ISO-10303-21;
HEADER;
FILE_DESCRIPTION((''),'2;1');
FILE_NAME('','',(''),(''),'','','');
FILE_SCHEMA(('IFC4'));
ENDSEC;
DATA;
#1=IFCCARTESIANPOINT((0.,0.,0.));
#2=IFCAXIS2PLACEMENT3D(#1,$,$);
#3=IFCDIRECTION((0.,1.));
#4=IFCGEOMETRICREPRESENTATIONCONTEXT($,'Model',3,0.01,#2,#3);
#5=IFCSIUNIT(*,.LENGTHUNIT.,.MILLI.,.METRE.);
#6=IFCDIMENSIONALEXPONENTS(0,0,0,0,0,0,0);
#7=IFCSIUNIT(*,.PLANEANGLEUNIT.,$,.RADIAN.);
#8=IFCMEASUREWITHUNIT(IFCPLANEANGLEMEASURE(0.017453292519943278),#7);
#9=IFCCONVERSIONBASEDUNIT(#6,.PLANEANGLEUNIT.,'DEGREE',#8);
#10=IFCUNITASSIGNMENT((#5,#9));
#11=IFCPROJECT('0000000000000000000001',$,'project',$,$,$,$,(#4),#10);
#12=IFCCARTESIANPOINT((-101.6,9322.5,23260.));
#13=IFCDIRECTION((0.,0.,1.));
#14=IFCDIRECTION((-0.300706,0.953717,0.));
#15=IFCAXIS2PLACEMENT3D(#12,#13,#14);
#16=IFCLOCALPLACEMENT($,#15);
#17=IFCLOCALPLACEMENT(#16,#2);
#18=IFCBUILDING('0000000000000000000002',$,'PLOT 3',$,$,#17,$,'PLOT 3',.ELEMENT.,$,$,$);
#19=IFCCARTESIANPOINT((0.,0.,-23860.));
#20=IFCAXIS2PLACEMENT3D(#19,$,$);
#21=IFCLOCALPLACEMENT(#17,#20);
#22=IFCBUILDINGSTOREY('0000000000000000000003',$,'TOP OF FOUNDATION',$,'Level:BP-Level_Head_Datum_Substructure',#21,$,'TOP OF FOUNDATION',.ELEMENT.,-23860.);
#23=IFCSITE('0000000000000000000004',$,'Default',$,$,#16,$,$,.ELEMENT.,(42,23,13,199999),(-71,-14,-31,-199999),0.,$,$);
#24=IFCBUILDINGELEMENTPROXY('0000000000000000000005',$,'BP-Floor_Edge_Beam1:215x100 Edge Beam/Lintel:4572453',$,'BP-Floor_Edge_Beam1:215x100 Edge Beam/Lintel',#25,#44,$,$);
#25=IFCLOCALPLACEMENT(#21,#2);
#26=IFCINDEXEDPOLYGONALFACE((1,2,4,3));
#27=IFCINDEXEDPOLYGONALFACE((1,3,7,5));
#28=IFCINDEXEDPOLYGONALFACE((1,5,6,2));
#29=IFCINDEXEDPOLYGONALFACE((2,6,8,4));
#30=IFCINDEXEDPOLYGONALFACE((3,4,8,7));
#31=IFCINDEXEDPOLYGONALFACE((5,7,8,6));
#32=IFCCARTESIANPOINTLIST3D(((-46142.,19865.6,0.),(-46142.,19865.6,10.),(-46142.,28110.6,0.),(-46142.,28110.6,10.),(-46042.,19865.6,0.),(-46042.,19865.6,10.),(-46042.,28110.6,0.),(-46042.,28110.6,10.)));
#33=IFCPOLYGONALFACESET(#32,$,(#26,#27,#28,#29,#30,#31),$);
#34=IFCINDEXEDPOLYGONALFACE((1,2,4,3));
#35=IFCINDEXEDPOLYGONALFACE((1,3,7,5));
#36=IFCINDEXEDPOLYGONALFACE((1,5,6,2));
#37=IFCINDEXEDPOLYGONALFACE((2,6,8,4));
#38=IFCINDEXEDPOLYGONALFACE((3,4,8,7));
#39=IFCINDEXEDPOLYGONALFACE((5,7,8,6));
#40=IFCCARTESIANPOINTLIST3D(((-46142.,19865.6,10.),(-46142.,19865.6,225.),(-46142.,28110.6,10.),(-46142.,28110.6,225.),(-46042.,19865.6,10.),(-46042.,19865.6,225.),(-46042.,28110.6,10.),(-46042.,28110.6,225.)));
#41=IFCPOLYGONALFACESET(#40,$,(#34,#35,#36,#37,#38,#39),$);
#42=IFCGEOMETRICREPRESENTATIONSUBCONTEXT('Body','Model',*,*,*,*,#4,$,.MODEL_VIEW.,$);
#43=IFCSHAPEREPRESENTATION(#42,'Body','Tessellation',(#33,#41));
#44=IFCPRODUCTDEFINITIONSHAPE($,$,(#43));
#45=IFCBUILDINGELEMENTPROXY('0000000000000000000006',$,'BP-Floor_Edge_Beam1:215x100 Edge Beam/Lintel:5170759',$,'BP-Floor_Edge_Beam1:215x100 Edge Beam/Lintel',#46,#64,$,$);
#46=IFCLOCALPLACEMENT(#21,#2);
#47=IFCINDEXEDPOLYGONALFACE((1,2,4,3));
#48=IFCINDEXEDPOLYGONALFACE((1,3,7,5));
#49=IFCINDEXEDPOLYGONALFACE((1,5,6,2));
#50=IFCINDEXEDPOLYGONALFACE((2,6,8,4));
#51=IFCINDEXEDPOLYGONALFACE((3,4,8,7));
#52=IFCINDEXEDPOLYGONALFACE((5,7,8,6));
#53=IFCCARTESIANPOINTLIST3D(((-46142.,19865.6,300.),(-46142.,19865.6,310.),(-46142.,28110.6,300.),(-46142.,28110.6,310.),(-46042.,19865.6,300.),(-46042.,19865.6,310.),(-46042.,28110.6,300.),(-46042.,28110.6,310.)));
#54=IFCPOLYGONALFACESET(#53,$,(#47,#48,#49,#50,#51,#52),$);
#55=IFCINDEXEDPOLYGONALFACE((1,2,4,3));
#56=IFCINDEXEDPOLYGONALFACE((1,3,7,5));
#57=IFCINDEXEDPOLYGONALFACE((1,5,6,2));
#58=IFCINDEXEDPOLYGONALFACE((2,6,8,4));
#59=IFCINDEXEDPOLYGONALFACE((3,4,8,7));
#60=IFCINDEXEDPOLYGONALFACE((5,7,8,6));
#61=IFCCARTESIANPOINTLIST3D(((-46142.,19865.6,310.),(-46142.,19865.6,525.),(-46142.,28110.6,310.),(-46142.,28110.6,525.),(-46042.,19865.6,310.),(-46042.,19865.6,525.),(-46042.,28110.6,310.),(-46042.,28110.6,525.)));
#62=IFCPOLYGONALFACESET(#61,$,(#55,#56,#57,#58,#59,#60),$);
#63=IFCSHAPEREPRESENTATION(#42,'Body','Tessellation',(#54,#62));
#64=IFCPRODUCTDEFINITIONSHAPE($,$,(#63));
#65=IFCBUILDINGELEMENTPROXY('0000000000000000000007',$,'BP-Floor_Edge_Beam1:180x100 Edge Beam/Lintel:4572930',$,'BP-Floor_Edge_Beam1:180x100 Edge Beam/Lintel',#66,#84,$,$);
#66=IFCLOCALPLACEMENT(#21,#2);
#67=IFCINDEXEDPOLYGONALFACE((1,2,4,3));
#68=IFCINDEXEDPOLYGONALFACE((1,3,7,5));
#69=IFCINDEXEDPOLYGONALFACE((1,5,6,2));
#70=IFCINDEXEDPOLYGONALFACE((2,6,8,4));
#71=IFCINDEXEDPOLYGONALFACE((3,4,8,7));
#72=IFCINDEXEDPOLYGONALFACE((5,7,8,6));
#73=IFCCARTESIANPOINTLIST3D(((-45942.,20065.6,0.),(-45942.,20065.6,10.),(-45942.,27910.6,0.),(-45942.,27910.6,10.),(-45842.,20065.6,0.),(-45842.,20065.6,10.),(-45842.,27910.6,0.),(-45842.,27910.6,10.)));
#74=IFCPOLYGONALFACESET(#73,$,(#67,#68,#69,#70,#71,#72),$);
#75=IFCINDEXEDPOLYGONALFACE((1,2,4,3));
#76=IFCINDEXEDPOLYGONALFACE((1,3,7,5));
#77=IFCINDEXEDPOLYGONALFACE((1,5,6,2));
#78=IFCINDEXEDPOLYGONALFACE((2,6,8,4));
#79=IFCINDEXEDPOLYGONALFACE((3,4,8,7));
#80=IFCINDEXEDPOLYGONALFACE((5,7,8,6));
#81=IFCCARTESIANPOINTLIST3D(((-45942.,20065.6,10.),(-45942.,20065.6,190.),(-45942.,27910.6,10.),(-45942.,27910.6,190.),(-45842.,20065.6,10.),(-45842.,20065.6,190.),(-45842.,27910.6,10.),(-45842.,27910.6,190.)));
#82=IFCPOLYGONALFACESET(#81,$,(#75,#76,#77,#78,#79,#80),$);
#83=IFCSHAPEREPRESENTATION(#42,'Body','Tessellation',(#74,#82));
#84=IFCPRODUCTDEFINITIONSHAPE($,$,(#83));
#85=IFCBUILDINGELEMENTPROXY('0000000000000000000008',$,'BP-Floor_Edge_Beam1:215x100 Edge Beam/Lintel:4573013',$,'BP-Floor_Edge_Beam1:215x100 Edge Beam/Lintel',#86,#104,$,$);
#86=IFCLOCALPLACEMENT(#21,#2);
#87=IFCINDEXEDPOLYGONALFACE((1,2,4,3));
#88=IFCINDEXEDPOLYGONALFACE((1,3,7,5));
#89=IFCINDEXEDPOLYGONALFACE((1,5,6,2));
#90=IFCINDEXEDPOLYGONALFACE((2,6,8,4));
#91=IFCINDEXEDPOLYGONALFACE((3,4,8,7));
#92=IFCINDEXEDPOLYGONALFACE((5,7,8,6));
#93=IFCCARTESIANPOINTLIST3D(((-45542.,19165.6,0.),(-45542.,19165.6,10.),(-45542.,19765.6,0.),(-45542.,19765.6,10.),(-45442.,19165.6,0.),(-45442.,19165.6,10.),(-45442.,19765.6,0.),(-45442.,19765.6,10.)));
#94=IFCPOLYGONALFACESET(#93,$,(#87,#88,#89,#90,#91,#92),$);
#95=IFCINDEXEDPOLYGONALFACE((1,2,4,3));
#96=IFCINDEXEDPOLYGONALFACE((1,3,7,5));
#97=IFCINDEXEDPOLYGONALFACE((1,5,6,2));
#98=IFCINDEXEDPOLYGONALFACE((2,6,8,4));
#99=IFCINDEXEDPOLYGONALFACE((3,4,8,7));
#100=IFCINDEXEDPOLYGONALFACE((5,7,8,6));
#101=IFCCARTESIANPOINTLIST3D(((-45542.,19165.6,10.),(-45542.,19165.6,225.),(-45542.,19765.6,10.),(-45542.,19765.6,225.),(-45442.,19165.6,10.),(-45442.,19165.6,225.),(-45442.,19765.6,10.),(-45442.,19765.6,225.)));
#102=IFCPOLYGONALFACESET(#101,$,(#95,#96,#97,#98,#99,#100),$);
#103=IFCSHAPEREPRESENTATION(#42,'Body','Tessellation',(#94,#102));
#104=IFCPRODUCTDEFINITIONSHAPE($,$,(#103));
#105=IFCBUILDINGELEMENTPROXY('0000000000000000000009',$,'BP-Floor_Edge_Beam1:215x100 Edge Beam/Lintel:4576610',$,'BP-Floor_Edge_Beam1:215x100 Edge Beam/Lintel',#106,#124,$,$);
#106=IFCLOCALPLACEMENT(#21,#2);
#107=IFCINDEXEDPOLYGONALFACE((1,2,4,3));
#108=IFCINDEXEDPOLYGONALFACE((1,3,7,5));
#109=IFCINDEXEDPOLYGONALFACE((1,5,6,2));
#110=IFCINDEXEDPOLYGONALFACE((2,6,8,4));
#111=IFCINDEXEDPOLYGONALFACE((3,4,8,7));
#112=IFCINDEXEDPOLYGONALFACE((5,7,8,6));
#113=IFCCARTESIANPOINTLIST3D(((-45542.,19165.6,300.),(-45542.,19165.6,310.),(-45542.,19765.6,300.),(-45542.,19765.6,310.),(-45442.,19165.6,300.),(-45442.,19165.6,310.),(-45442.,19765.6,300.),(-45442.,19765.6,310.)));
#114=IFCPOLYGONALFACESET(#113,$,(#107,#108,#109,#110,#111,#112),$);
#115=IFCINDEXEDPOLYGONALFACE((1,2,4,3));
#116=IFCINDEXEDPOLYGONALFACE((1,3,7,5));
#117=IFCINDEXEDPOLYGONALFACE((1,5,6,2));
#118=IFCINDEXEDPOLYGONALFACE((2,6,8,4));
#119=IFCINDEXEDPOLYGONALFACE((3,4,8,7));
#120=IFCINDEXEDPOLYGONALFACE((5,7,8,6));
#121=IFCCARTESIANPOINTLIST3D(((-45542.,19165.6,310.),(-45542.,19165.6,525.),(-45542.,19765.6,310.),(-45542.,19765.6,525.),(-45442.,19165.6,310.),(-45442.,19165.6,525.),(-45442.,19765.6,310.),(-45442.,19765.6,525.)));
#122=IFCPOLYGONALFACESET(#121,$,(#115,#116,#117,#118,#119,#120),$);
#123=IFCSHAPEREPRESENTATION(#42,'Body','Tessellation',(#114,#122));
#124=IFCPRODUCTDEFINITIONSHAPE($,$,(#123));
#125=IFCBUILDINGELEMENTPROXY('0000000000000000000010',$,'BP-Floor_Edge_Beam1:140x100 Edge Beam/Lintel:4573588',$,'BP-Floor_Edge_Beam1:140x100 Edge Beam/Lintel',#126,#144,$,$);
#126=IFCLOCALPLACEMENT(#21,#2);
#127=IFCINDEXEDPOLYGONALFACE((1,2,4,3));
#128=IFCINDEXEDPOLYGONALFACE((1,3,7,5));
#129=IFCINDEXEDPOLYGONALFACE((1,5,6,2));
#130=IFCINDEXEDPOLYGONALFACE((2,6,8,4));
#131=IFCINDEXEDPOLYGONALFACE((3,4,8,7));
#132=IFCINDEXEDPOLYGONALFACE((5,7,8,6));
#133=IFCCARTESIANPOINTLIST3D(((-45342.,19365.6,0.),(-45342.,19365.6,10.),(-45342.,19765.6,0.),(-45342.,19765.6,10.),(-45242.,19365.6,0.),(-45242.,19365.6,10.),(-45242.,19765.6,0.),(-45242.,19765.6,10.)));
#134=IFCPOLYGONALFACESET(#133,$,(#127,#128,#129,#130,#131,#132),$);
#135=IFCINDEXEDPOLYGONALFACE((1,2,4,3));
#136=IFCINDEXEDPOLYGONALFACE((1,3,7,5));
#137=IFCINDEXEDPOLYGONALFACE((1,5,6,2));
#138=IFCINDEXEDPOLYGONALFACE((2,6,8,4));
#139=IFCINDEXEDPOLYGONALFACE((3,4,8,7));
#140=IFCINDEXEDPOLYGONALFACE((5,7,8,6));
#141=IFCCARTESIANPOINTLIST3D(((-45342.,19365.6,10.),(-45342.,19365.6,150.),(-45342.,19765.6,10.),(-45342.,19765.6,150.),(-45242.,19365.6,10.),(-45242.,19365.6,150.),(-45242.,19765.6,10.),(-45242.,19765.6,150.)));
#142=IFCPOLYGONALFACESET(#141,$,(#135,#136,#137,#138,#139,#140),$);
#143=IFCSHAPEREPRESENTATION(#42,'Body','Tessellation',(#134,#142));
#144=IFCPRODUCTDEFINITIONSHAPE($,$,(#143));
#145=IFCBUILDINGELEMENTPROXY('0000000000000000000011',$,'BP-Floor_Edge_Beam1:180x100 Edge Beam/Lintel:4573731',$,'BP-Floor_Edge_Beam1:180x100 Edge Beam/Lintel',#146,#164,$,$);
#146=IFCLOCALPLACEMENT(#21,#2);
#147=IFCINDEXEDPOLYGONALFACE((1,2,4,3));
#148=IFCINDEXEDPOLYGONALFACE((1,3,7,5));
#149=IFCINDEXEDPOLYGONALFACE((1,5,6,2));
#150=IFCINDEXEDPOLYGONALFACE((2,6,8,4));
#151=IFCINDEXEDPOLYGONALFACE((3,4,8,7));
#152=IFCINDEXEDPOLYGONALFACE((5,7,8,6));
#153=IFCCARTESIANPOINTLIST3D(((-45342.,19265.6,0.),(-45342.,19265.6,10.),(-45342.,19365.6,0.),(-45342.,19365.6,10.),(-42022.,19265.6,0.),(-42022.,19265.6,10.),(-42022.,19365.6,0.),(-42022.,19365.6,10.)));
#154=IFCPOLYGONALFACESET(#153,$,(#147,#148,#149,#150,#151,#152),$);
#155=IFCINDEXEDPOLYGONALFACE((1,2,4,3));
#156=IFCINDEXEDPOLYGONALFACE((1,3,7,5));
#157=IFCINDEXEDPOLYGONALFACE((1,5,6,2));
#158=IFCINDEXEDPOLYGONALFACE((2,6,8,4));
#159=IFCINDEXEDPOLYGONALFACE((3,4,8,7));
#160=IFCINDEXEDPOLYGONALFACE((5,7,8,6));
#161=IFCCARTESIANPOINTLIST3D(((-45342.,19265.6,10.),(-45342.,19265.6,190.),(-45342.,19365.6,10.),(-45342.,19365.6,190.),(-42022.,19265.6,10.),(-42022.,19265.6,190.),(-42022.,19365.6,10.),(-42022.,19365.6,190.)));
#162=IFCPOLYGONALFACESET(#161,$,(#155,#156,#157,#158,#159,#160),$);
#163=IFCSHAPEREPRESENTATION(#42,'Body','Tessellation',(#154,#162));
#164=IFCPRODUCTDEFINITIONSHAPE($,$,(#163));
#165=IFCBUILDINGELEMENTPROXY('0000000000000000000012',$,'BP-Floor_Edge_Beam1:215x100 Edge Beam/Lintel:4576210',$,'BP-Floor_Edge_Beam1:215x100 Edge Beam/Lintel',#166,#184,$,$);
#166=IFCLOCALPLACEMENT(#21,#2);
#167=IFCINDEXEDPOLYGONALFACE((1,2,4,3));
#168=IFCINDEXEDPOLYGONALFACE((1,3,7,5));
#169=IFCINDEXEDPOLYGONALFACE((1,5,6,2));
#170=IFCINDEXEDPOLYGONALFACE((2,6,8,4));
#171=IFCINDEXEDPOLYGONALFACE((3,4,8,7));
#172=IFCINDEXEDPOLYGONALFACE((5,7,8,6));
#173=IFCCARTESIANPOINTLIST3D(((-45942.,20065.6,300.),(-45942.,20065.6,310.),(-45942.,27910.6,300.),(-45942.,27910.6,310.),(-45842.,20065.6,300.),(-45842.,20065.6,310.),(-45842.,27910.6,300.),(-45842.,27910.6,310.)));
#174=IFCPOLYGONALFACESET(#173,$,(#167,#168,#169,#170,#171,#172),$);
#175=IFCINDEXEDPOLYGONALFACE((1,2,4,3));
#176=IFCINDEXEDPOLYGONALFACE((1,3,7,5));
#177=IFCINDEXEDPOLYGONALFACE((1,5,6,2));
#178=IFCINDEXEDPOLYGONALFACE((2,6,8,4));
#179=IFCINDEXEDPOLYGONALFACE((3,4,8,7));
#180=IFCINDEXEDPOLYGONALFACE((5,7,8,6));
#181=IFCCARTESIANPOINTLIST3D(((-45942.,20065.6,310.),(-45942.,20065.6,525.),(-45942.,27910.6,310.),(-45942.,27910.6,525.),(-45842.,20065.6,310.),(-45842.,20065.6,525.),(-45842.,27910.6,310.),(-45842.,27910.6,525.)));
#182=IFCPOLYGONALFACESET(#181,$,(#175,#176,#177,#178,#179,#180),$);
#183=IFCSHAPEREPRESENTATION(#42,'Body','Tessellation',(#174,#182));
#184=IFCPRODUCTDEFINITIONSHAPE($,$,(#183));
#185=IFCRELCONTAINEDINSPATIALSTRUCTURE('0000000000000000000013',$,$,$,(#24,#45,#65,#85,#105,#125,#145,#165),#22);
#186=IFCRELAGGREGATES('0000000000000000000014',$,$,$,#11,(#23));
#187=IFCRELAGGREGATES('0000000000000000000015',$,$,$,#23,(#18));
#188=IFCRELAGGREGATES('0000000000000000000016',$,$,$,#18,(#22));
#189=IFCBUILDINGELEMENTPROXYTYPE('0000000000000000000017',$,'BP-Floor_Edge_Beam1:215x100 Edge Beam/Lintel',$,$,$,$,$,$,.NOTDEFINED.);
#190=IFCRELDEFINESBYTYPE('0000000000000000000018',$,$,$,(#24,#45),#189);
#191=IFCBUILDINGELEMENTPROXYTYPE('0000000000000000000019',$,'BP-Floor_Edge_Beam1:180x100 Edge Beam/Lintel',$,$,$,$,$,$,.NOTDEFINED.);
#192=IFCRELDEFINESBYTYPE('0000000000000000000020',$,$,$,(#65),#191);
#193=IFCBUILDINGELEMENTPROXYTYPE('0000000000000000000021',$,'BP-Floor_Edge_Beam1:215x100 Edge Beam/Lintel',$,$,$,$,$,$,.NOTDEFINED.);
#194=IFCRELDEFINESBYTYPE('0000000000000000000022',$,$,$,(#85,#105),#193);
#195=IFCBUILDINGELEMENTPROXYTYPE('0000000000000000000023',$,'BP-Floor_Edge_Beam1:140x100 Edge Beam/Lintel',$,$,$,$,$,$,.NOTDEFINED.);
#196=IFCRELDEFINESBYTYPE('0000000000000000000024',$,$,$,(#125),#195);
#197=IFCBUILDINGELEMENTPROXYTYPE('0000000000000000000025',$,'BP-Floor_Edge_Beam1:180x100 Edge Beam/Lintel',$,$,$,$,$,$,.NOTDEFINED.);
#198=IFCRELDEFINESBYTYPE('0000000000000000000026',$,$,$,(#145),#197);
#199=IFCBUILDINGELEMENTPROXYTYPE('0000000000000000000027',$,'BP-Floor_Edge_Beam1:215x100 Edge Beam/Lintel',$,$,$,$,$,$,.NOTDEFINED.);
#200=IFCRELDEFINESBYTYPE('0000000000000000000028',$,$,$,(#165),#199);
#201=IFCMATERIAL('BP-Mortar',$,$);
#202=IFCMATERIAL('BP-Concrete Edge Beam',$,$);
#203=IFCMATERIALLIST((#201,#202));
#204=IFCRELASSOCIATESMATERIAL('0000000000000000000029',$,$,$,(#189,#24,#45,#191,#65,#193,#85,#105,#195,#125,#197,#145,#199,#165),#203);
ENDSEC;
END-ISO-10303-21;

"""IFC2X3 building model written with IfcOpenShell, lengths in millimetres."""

from ifc_helpers import new_model, entity, si_unit, converted_unit, direction, frame, frame_2d, origin, origin_2d_with_axis, place, context, subcontext, project, spatial, rectangle, extrude, source, transform, mapped, material, material_list, type_object, type_shapes, element, save


model = new_model("IFC2X3")

# Units and contexts
model_context = context("Model", 3, precision=0.01, world=origin(), true_north=direction((0.0, 1.0)))
body_context = subcontext(model_context, "Body", "Model", "MODEL_VIEW")
ifc_project = project(units=[si_unit("LENGTHUNIT", "METRE", prefix="MILLI"), converted_unit("PLANEANGLEUNIT", "DEGREE", entity("IfcPlaneAngleMeasure", 0.017453292519943278), si_unit("PLANEANGLEUNIT", "RADIAN"), dimensions=[0, 0, 0, 0, 0, 0, 0])], contexts=[model_context])

# Site, building, storey
site_placement = place(None, frame((-101.6, 9322.5, 23260.0), z_axis=(0.0, 0.0, 1.0), x_axis=(-0.300706, 0.953717, 0.0)))
site = spatial("IfcSite", under=ifc_project, at=site_placement, Name="Default", CompositionType="ELEMENT", RefLatitude=(42, 23, 13, 199999), RefLongitude=(-71, -14, -31, -199999), RefElevation=0.0)
building_placement = place(site_placement, origin())
building = spatial("IfcBuilding", under=site, at=building_placement, Name="PLOT 3", LongName="PLOT 3", CompositionType="ELEMENT")
storey_placement = place(building_placement, frame((0.0, 0.0, -23860.0)))
storey = spatial("IfcBuildingStorey", under=building, at=storey_placement, Name="TOP OF FOUNDATION", ObjectType="Level:BP-Level_Head_Datum_Substructure", LongName="TOP OF FOUNDATION", CompositionType="ELEMENT", Elevation=-23860.0)

# Building element proxies
ifc_material_1 = material(Name="BP-Mortar")
ifc_material_2 = material(Name="BP-Concrete Edge Beam")
ifc_material_list = material_list([ifc_material_1, ifc_material_2])
building_element_proxy_type_1 = type_object("IfcBuildingElementProxyType", Name="BP-Floor_Edge_Beam1:215x100 Edge Beam/Lintel", PredefinedType="NOTDEFINED", material=ifc_material_list)
shared_shape_1 = source(origin(), body_context, "Body", "SweptSolid", [
    extrude(rectangle(XDim=100.0, YDim=8245.0, at=frame_2d((0.0, 0.0), x_axis=(1.0, 0.0))), frame((0.0, 0.0, 0.0), z_axis=(0.0, 0.0, 1.0), x_axis=(0.0, 1.0, 0.0)), (0.0, 0.0, 1.0), 10.0),
    extrude(rectangle(XDim=100.0, YDim=8245.0, at=origin_2d_with_axis()), frame((0.0, 0.0, 10.0), z_axis=(0.0, 0.0, 1.0), x_axis=(0.0, 1.0, 0.0)), (0.0, 0.0, 1.0), 215.0),
])
type_shapes(building_element_proxy_type_1, [shared_shape_1])
for number, where, z_axis, x_axis, name in (
    (1, (-46092.0, 23988.1, 0.0), (0.0, 0.0, 1.0), (0.0, 1.0, 0.0), "BP-Floor_Edge_Beam1:215x100 Edge Beam/Lintel:4572453"),
    (2, (-46092.0, 23988.1, 300.0), (0.0, 0.0, 1.0), (0.0, 1.0, 0.0), "BP-Floor_Edge_Beam1:215x100 Edge Beam/Lintel:5170759"),
):
    element("IfcBuildingElementProxy", number, at=place(storey_placement, frame(where, z_axis=z_axis, x_axis=x_axis)), inside=storey, type_object=building_element_proxy_type_1, material=ifc_material_list, Name=name, ObjectType="BP-Floor_Edge_Beam1:215x100 Edge Beam/Lintel", context=body_context, shape_type="MappedRepresentation", body=[
        mapped(shared_shape_1, transform((0.0, 0.0, 0.0), scale=1.0)),
    ])
building_element_proxy_type_2 = type_object("IfcBuildingElementProxyType", Name="BP-Floor_Edge_Beam1:180x100 Edge Beam/Lintel", PredefinedType="NOTDEFINED", material=ifc_material_list)
shared_shape_2 = source(origin(), body_context, "Body", "SweptSolid", [
    extrude(rectangle(XDim=100.0, YDim=7845.0, at=frame_2d((0.0, 0.0), x_axis=(1.0, 0.0))), frame((0.0, 0.0, 0.0), z_axis=(0.0, 0.0, 1.0), x_axis=(0.0, 1.0, 0.0)), (0.0, 0.0, 1.0), 10.0),
    extrude(rectangle(XDim=100.0, YDim=7845.0, at=origin_2d_with_axis()), frame((0.0, 0.0, 10.0), z_axis=(0.0, 0.0, 1.0), x_axis=(0.0, 1.0, 0.0)), (0.0, 0.0, 1.0), 180.0),
])
type_shapes(building_element_proxy_type_2, [shared_shape_2])
proxy_1_placement = place(storey_placement, frame((-45892.0, 23988.1, 0.0), z_axis=(0.0, 0.0, 1.0), x_axis=(0.0, 1.0, 0.0)))
element("IfcBuildingElementProxy", 3, at=proxy_1_placement, inside=storey, type_object=building_element_proxy_type_2, material=ifc_material_list, Name="BP-Floor_Edge_Beam1:180x100 Edge Beam/Lintel:4572930", ObjectType="BP-Floor_Edge_Beam1:180x100 Edge Beam/Lintel", context=body_context, shape_type="MappedRepresentation", body=[
    mapped(shared_shape_2, transform((0.0, 0.0, 0.0), scale=1.0)),
])
building_element_proxy_type_3 = type_object("IfcBuildingElementProxyType", Name="BP-Floor_Edge_Beam1:215x100 Edge Beam/Lintel", PredefinedType="NOTDEFINED", material=ifc_material_list)
shared_shape_3 = source(origin(), body_context, "Body", "SweptSolid", [
    extrude(rectangle(XDim=100.0, YDim=600.0, at=frame_2d((0.0, 0.0), x_axis=(1.0, 0.0))), frame((0.0, 0.0, 0.0), z_axis=(0.0, 0.0, 1.0), x_axis=(0.0, 1.0, 0.0)), (0.0, 0.0, 1.0), 10.0),
    extrude(rectangle(XDim=100.0, YDim=600.0, at=origin_2d_with_axis()), frame((0.0, 0.0, 10.0), z_axis=(0.0, 0.0, 1.0), x_axis=(0.0, 1.0, 0.0)), (0.0, 0.0, 1.0), 215.0),
])
type_shapes(building_element_proxy_type_3, [shared_shape_3])
for number, where, z_axis, x_axis, name in (
    (4, (-45492.0, 19465.6, 0.0), (0.0, 0.0, 1.0), (0.0, 1.0, 0.0), "BP-Floor_Edge_Beam1:215x100 Edge Beam/Lintel:4573013"),
    (5, (-45492.0, 19465.6, 300.0), (0.0, 0.0, 1.0), (0.0, 1.0, 0.0), "BP-Floor_Edge_Beam1:215x100 Edge Beam/Lintel:4576610"),
):
    element("IfcBuildingElementProxy", number, at=place(storey_placement, frame(where, z_axis=z_axis, x_axis=x_axis)), inside=storey, type_object=building_element_proxy_type_3, material=ifc_material_list, Name=name, ObjectType="BP-Floor_Edge_Beam1:215x100 Edge Beam/Lintel", context=body_context, shape_type="MappedRepresentation", body=[
        mapped(shared_shape_3, transform((0.0, 0.0, 0.0), scale=1.0)),
    ])
building_element_proxy_type_4 = type_object("IfcBuildingElementProxyType", Name="BP-Floor_Edge_Beam1:140x100 Edge Beam/Lintel", PredefinedType="NOTDEFINED", material=ifc_material_list)
shared_shape_4 = source(origin(), body_context, "Body", "SweptSolid", [
    extrude(rectangle(XDim=100.0, YDim=400.0, at=frame_2d((0.0, 0.0), x_axis=(1.0, 0.0))), frame((0.0, 0.0, 0.0), z_axis=(0.0, 0.0, 1.0), x_axis=(0.0, 1.0, 0.0)), (0.0, 0.0, 1.0), 10.0),
    extrude(rectangle(XDim=100.0, YDim=400.0, at=origin_2d_with_axis()), frame((0.0, 0.0, 10.0), z_axis=(0.0, 0.0, 1.0), x_axis=(0.0, 1.0, 0.0)), (0.0, 0.0, 1.0), 140.0),
])
type_shapes(building_element_proxy_type_4, [shared_shape_4])
proxy_2_placement = place(storey_placement, frame((-45292.0, 19565.6, 0.0), z_axis=(0.0, 0.0, 1.0), x_axis=(0.0, 1.0, 0.0)))
element("IfcBuildingElementProxy", 6, at=proxy_2_placement, inside=storey, type_object=building_element_proxy_type_4, material=ifc_material_list, Name="BP-Floor_Edge_Beam1:140x100 Edge Beam/Lintel:4573588", ObjectType="BP-Floor_Edge_Beam1:140x100 Edge Beam/Lintel", context=body_context, shape_type="MappedRepresentation", body=[
    mapped(shared_shape_4, transform((0.0, 0.0, 0.0), scale=1.0)),
])
building_element_proxy_type_5 = type_object("IfcBuildingElementProxyType", Name="BP-Floor_Edge_Beam1:180x100 Edge Beam/Lintel", PredefinedType="NOTDEFINED", material=ifc_material_list)
shared_shape_5 = source(origin(), body_context, "Body", "SweptSolid", [
    extrude(rectangle(XDim=100.0, YDim=3320.0, at=origin_2d_with_axis()), frame((0.0, 0.0, 0.0), z_axis=(0.0, 0.0, 1.0), x_axis=(0.0, 1.0, 0.0)), (0.0, 0.0, 1.0), 10.0),
    extrude(rectangle(XDim=100.0, YDim=3320.0, at=origin_2d_with_axis()), frame((0.0, 0.0, 10.0), z_axis=(0.0, 0.0, 1.0), x_axis=(0.0, 1.0, 0.0)), (0.0, 0.0, 1.0), 180.0),
])
type_shapes(building_element_proxy_type_5, [shared_shape_5])
proxy_3_placement = place(storey_placement, frame((-43682.0, 19315.6, 0.0), z_axis=(0.0, 0.0, 1.0), x_axis=(-1.0, 0.0, 0.0)))
element("IfcBuildingElementProxy", 7, at=proxy_3_placement, inside=storey, type_object=building_element_proxy_type_5, material=ifc_material_list, Name="BP-Floor_Edge_Beam1:180x100 Edge Beam/Lintel:4573731", ObjectType="BP-Floor_Edge_Beam1:180x100 Edge Beam/Lintel", context=body_context, shape_type="MappedRepresentation", body=[
    mapped(shared_shape_5, transform((0.0, 0.0, 0.0), scale=1.0)),
])
building_element_proxy_type_6 = type_object("IfcBuildingElementProxyType", Name="BP-Floor_Edge_Beam1:215x100 Edge Beam/Lintel", PredefinedType="NOTDEFINED", material=ifc_material_list)
shared_shape_6 = source(origin(), body_context, "Body", "SweptSolid", [
    extrude(rectangle(XDim=100.0, YDim=7845.0, at=frame_2d((0.0, 0.0), x_axis=(1.0, 0.0))), frame((0.0, 0.0, 0.0), z_axis=(0.0, 0.0, 1.0), x_axis=(0.0, 1.0, 0.0)), (0.0, 0.0, 1.0), 10.0),
    extrude(rectangle(XDim=100.0, YDim=7845.0, at=origin_2d_with_axis()), frame((0.0, 0.0, 10.0), z_axis=(0.0, 0.0, 1.0), x_axis=(0.0, 1.0, 0.0)), (0.0, 0.0, 1.0), 215.0),
])
type_shapes(building_element_proxy_type_6, [shared_shape_6])
proxy_4_placement = place(storey_placement, frame((-45892.0, 23988.1, 300.0), z_axis=(0.0, 0.0, 1.0), x_axis=(0.0, 1.0, 0.0)))
element("IfcBuildingElementProxy", 8, at=proxy_4_placement, inside=storey, type_object=building_element_proxy_type_6, material=ifc_material_list, Name="BP-Floor_Edge_Beam1:215x100 Edge Beam/Lintel:4576210", ObjectType="BP-Floor_Edge_Beam1:215x100 Edge Beam/Lintel", context=body_context, shape_type="MappedRepresentation", body=[
    mapped(shared_shape_6, transform((0.0, 0.0, 0.0), scale=1.0)),
])

save(model, "model.ifc")
